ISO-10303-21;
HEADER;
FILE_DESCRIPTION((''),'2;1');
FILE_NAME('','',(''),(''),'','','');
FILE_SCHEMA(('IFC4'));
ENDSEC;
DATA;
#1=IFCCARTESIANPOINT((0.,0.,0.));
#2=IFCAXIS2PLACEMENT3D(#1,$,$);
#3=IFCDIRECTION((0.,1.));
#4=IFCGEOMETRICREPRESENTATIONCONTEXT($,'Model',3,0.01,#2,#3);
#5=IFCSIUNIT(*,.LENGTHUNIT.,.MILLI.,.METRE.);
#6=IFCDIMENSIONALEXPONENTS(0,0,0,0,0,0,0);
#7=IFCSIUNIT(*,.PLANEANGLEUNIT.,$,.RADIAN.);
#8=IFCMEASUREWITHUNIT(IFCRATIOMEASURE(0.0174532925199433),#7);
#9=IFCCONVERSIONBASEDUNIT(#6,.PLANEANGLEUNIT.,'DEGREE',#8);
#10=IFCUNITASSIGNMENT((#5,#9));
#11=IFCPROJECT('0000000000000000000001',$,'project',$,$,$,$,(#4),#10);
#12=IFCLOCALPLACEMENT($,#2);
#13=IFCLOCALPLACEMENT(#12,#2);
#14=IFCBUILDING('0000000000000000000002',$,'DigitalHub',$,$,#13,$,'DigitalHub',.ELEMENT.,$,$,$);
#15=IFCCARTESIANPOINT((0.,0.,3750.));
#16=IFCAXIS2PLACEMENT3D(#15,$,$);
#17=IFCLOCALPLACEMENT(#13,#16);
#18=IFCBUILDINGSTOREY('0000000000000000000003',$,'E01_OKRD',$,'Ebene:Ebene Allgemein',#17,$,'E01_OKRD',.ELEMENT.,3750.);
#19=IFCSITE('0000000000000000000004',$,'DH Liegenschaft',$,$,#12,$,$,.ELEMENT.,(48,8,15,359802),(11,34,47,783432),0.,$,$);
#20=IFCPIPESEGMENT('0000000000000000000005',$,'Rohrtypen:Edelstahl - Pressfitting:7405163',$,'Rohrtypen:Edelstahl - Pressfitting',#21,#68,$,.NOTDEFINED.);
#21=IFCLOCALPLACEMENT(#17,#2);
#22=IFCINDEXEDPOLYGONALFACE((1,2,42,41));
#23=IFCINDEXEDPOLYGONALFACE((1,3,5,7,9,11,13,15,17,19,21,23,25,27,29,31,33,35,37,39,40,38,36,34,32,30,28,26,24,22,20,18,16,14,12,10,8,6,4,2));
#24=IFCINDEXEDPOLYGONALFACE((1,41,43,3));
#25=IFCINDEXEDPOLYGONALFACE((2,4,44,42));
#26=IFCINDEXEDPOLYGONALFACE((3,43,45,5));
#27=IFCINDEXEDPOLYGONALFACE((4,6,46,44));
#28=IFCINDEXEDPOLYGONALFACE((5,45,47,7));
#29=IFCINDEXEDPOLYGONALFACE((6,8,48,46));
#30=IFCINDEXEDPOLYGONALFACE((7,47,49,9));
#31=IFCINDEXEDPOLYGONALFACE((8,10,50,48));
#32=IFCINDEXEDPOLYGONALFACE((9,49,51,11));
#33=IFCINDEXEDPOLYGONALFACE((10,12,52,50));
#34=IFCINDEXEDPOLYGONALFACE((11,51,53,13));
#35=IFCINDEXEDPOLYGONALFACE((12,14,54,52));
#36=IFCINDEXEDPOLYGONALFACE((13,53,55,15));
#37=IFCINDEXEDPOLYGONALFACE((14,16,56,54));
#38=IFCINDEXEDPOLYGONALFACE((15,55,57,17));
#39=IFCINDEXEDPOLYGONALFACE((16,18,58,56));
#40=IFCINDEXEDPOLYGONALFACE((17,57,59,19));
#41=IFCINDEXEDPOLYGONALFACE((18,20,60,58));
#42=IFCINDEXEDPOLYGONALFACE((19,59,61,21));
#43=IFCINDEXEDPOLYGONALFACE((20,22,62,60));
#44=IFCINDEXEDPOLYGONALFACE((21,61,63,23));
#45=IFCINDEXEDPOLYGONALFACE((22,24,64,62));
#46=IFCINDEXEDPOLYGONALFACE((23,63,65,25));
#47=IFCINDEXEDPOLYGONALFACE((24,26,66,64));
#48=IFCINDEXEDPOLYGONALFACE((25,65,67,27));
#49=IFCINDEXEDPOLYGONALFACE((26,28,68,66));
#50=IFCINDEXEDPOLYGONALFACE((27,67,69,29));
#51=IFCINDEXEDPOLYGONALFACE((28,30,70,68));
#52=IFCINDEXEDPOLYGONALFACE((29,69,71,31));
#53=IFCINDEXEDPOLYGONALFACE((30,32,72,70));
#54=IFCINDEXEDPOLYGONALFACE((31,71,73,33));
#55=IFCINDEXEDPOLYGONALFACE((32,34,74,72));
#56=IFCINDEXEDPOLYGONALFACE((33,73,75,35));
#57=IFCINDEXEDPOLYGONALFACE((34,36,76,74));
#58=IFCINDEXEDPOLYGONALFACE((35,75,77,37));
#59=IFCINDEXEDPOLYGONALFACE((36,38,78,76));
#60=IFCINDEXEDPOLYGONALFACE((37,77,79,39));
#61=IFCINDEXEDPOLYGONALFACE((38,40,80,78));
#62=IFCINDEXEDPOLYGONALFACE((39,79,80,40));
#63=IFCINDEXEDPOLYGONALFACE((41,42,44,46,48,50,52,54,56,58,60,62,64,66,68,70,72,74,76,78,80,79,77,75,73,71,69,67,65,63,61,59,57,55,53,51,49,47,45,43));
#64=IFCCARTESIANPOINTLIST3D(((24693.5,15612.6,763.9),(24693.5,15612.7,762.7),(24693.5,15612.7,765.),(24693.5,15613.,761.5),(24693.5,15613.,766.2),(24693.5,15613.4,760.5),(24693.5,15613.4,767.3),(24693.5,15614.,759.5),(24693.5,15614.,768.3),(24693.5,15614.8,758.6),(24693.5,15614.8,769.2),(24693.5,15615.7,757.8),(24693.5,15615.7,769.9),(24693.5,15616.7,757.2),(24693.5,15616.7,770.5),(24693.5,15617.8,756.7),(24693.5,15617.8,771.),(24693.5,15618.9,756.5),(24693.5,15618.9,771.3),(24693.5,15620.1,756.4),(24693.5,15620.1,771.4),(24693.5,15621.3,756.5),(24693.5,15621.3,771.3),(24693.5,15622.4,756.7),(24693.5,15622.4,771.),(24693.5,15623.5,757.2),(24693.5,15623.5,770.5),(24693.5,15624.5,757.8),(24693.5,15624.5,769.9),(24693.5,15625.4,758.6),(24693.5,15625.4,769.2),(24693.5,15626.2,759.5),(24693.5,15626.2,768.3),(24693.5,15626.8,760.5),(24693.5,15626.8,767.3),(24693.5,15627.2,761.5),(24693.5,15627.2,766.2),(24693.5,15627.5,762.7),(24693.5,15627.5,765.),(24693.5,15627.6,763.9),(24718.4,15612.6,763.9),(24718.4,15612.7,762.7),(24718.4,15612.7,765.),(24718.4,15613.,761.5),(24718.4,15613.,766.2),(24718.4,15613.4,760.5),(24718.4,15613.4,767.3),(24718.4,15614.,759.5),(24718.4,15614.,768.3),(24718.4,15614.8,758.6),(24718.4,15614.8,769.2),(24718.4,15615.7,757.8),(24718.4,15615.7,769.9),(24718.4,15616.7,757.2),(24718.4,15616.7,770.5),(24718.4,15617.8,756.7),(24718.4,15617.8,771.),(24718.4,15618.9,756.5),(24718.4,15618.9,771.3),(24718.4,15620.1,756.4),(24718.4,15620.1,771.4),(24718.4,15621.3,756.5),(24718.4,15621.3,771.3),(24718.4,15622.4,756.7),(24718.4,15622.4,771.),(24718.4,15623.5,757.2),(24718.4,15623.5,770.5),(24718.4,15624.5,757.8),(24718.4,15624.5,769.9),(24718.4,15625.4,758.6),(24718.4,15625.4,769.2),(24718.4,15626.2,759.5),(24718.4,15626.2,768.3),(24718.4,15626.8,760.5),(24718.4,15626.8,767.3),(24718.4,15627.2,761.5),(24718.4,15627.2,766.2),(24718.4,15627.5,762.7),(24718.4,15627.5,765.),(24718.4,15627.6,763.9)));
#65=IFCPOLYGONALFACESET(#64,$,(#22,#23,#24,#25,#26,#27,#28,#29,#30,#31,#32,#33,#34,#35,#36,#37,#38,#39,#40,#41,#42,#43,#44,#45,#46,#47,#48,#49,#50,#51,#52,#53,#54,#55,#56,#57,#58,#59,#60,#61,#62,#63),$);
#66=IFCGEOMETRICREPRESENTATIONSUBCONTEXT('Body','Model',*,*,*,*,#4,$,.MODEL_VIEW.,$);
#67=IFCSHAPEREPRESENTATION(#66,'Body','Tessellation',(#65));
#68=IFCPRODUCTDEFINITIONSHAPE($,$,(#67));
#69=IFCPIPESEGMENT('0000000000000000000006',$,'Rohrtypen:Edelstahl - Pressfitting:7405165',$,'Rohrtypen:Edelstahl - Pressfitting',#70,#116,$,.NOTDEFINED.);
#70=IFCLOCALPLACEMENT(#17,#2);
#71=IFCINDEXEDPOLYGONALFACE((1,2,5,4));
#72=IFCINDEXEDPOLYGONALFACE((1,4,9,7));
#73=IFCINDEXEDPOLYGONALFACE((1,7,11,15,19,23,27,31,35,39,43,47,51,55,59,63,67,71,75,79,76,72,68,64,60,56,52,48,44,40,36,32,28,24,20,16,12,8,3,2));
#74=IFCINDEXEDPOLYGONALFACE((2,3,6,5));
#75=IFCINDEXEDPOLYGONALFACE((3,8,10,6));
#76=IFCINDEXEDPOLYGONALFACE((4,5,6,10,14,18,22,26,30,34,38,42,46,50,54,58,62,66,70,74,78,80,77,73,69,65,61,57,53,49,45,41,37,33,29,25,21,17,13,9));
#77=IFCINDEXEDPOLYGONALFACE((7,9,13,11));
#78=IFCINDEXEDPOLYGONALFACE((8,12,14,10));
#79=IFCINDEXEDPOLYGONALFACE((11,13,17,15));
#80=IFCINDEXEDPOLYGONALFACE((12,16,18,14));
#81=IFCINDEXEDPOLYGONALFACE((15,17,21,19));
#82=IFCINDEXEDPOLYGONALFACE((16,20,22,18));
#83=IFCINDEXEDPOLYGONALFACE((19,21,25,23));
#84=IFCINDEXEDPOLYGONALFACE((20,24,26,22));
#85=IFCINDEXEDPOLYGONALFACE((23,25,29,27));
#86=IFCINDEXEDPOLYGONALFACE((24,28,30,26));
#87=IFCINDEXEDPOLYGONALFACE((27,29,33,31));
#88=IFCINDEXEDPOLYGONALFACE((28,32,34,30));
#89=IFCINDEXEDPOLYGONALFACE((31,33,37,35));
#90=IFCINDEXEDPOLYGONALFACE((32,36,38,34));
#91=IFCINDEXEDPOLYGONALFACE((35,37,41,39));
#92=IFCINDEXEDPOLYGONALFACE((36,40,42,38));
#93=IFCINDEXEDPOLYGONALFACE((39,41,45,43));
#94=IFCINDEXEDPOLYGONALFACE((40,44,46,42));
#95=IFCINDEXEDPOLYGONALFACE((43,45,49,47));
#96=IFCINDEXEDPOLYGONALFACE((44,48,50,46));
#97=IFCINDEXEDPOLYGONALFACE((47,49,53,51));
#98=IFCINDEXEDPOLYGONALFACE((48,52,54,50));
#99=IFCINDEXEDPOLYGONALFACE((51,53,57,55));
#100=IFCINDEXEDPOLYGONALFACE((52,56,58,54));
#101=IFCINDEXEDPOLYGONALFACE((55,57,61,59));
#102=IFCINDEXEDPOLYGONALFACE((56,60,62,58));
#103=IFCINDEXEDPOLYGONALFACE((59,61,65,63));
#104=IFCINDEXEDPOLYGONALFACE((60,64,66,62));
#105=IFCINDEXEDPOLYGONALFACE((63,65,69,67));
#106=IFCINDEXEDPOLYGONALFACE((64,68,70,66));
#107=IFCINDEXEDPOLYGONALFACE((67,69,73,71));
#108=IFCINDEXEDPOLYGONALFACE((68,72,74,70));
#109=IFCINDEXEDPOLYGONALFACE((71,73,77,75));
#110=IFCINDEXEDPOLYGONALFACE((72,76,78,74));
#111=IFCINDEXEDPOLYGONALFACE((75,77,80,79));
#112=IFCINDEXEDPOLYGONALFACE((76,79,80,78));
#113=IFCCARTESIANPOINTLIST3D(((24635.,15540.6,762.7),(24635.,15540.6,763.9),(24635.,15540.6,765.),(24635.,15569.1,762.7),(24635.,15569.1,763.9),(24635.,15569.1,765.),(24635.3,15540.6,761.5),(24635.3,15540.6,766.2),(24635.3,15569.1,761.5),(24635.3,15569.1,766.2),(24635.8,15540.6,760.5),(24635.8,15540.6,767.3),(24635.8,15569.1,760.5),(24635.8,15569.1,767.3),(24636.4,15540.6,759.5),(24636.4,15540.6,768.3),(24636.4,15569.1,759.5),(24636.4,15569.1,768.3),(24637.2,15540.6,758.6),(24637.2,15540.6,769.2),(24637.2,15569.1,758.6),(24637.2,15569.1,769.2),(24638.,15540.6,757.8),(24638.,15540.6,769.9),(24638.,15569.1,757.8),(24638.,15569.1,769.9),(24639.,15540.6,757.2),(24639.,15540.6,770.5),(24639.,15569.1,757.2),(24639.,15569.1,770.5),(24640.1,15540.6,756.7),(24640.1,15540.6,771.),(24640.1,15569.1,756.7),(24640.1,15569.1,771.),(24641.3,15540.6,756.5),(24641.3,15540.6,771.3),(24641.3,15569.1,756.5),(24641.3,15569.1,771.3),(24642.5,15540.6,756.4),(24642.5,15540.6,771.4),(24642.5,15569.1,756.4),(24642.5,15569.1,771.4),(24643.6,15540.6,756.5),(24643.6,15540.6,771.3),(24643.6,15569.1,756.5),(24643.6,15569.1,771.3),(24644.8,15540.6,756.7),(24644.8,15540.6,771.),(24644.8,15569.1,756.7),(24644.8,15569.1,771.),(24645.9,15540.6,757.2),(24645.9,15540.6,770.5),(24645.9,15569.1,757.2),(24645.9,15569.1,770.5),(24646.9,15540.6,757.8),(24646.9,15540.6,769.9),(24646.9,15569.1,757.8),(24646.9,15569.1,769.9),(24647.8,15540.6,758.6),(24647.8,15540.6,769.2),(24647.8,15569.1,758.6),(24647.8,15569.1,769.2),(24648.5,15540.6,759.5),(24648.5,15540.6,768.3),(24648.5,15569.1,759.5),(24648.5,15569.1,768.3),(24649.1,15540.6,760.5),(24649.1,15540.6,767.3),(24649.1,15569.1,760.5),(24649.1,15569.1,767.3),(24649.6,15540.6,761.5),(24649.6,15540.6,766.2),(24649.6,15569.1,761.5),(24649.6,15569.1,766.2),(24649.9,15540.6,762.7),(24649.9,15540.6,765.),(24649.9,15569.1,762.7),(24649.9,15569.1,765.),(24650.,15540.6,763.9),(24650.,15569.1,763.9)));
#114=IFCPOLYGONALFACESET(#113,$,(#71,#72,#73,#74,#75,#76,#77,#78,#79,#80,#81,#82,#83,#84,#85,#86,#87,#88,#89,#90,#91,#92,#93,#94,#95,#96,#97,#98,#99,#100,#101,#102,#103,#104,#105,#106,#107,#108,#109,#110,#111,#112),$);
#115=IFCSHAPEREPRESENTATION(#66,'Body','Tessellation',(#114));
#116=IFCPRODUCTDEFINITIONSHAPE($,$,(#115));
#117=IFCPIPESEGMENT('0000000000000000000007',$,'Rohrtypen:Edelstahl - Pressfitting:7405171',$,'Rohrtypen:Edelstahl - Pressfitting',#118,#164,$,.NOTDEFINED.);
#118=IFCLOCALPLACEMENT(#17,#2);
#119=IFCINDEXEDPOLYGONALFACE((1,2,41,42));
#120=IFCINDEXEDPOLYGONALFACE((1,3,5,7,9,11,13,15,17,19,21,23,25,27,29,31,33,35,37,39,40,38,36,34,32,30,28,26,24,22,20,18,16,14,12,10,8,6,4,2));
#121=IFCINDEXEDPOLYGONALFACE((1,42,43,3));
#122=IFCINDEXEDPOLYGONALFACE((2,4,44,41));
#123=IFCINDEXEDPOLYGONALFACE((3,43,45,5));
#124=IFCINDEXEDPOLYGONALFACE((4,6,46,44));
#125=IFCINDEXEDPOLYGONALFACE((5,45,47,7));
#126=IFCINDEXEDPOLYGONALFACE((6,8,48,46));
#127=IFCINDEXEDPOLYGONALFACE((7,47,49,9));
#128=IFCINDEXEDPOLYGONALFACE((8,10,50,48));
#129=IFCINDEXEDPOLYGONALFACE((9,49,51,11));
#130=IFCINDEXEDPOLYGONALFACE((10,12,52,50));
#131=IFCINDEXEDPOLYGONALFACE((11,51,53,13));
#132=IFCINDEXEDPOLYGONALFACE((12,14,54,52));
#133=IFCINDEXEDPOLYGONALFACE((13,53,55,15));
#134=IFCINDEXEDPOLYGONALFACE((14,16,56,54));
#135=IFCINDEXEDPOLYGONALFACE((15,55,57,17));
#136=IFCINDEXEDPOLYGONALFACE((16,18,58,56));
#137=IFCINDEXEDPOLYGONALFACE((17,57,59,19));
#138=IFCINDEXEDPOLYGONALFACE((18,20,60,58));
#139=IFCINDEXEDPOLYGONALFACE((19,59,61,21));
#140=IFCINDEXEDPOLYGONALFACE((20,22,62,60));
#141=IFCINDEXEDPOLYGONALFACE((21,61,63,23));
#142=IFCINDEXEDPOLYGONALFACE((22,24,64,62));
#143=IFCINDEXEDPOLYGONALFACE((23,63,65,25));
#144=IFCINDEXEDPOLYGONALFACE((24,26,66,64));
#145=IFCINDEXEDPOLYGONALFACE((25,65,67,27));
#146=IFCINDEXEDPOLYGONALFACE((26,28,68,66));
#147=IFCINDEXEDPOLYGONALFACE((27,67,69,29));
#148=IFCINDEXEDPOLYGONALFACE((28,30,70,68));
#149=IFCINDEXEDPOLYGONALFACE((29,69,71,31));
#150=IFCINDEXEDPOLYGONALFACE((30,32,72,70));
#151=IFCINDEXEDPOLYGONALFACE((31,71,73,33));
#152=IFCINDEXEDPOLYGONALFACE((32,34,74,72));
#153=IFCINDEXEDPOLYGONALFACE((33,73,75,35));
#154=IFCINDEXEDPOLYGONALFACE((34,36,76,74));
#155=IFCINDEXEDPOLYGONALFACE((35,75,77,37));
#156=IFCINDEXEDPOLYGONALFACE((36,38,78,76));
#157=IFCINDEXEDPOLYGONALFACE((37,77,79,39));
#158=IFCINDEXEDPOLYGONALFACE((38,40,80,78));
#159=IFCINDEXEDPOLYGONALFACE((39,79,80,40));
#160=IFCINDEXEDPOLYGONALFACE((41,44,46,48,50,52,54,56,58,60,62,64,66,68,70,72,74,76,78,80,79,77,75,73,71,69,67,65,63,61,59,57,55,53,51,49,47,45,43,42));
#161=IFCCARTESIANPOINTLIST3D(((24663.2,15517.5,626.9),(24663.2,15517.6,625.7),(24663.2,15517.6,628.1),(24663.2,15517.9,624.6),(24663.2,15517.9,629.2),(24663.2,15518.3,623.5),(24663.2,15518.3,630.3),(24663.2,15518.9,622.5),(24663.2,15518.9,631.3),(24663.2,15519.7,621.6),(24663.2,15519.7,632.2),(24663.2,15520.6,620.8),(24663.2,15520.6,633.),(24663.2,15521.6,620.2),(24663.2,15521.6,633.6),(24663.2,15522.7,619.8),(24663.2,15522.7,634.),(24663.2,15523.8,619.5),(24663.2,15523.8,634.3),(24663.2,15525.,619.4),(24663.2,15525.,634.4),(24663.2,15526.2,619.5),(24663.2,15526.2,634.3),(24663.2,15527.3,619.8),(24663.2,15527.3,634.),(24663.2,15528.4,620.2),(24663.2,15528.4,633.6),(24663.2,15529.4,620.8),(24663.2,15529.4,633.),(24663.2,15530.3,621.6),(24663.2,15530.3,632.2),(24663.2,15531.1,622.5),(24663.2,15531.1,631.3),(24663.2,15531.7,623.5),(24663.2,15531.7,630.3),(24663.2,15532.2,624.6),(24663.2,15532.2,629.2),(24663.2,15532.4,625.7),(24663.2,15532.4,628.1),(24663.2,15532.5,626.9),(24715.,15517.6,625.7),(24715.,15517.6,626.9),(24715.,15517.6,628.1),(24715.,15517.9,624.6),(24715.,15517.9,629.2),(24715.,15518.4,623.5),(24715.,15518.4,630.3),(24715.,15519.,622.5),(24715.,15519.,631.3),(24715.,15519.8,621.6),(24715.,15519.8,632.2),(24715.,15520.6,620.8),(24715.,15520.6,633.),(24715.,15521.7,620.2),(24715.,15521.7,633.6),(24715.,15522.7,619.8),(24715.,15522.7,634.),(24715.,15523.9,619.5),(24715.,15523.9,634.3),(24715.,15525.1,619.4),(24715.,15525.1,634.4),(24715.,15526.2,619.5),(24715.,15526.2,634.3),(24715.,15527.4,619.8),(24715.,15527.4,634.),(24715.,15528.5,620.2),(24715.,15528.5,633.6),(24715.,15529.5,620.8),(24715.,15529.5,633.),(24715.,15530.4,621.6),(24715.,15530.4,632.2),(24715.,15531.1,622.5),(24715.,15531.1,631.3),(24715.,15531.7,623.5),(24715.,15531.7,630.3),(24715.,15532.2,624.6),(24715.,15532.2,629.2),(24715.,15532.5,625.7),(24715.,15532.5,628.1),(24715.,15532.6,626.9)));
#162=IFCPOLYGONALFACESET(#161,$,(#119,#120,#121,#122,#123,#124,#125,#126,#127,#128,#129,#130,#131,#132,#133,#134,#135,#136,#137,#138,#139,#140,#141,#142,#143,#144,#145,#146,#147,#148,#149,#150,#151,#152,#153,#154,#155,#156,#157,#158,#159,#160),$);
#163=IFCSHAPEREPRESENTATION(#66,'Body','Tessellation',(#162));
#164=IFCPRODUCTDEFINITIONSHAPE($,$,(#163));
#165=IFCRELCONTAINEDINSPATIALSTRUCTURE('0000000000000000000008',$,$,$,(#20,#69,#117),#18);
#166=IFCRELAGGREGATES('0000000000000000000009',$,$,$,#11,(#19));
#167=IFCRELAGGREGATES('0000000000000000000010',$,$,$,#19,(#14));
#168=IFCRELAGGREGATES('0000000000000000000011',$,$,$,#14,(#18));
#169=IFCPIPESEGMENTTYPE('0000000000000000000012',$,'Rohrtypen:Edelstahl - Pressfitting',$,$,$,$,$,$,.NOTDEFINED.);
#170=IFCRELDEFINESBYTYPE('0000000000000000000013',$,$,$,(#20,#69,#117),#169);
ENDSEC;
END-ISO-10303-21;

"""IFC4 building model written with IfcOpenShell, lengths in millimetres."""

from ifc_helpers import new_model, entity, si_unit, converted_unit, direction, frame, origin, place, context, subcontext, project, spatial, indexed_curve, outline, extrude, type_object, element, save


model = new_model("IFC4")

# Units and contexts
model_context = context("Model", 3, precision=0.01, world=origin(), true_north=direction((0.0, 1.0)))
body_context = subcontext(model_context, "Body", "Model", "MODEL_VIEW")
ifc_project = project(units=[si_unit("LENGTHUNIT", "METRE", prefix="MILLI"), converted_unit("PLANEANGLEUNIT", "DEGREE", entity("IfcRatioMeasure", 0.0174532925199433), si_unit("PLANEANGLEUNIT", "RADIAN"), dimensions=[0, 0, 0, 0, 0, 0, 0])], contexts=[model_context])

# Site, building, storey
site_placement = place(None, origin())
site = spatial("IfcSite", under=ifc_project, at=site_placement, Name="DH Liegenschaft", CompositionType="ELEMENT", RefLatitude=(48, 8, 15, 359802), RefLongitude=(11, 34, 47, 783432), RefElevation=0.0)
building_placement = place(site_placement, origin())
building = spatial("IfcBuilding", under=site, at=building_placement, Name="DigitalHub", LongName="DigitalHub", CompositionType="ELEMENT")
storey_placement = place(building_placement, frame((0.0, 0.0, 3750.0)))
storey = spatial("IfcBuildingStorey", under=building, at=storey_placement, Name="E01_OKRD", ObjectType="Ebene:Ebene Allgemein", LongName="E01_OKRD", CompositionType="ELEMENT", Elevation=3750.0)

# Pipe segments
pipe_segment_type_1 = type_object("IfcPipeSegmentType", Name="Rohrtypen:Edelstahl - Pressfitting", PredefinedType="NOTDEFINED")
pipe_segment_1_placement = place(storey_placement, frame((24693.5, 15611.0, 754.8)))
element("IfcPipeSegment", 1, at=pipe_segment_1_placement, inside=storey, type_object=pipe_segment_type_1, Name="Rohrtypen:Edelstahl - Pressfitting:7405163", ObjectType="Rohrtypen:Edelstahl - Pressfitting", PredefinedType="NOTDEFINED", context=body_context, shape_type="SweptSolid", body=[
    extrude(outline(indexed_curve([(7.5, 0.0), (7.4, 1.2), (7.1, 2.3), (6.7, 3.4), (6.1, 4.4), (5.3, 5.3), (4.4, 6.1), (3.4, 6.7), (2.3, 7.1), (1.2, 7.4), (0.0, 7.5), (-1.2, 7.4), (-2.3, 7.1), (-3.4, 6.7), (-4.4, 6.1), (-5.3, 5.3), (-6.1, 4.4), (-6.7, 3.4), (-7.1, 2.3), (-7.4, 1.2), (-7.5, 0.0), (-7.4, -1.2), (-7.1, -2.3), (-6.7, -3.4), (-6.1, -4.4), (-5.3, -5.3), (-4.4, -6.1), (-3.4, -6.7), (-2.3, -7.1), (-1.2, -7.4), (0.0, -7.5), (1.2, -7.4), (2.3, -7.1), (3.4, -6.7), (4.4, -6.1), (5.3, -5.3), (6.1, -4.4), (6.7, -3.4), (7.1, -2.3), (7.4, -1.2), (7.5, 0.0)], self_intersect=False)), frame((0.0, 9.1, 9.1), z_axis=(1.0, 0.0, 0.0), x_axis=(0.0, 1.0, 0.0)), (0.0, 0.0, 1.0), 24.9),
])
pipe_segment_2_placement = place(storey_placement, frame((24633.4, 15540.6, 754.8)))
element("IfcPipeSegment", 2, at=pipe_segment_2_placement, inside=storey, type_object=pipe_segment_type_1, Name="Rohrtypen:Edelstahl - Pressfitting:7405165", ObjectType="Rohrtypen:Edelstahl - Pressfitting", PredefinedType="NOTDEFINED", context=body_context, shape_type="SweptSolid", body=[
    extrude(outline(indexed_curve([(7.5, 0.0), (7.4, 1.2), (7.1, 2.3), (6.7, 3.4), (6.1, 4.4), (5.3, 5.3), (4.4, 6.1), (3.4, 6.7), (2.3, 7.1), (1.2, 7.4), (0.0, 7.5), (-1.2, 7.4), (-2.3, 7.1), (-3.4, 6.7), (-4.4, 6.1), (-5.3, 5.3), (-6.1, 4.4), (-6.7, 3.4), (-7.1, 2.3), (-7.4, 1.2), (-7.5, 0.0), (-7.4, -1.2), (-7.1, -2.3), (-6.7, -3.4), (-6.1, -4.4), (-5.3, -5.3), (-4.4, -6.1), (-3.4, -6.7), (-2.3, -7.1), (-1.2, -7.4), (0.0, -7.5), (1.2, -7.4), (2.3, -7.1), (3.4, -6.7), (4.4, -6.1), (5.3, -5.3), (6.1, -4.4), (6.7, -3.4), (7.1, -2.3), (7.4, -1.2), (7.5, 0.0)], self_intersect=False)), frame((9.1, 0.0, 9.1), z_axis=(0.0, 1.0, 0.0), x_axis=(-1.0, 0.0, 0.0)), (0.0, 0.0, 1.0), 28.5),
])
pipe_segment_3_placement = place(storey_placement, frame((24663.2, 15515.9, 617.8)))
element("IfcPipeSegment", 3, at=pipe_segment_3_placement, inside=storey, type_object=pipe_segment_type_1, Name="Rohrtypen:Edelstahl - Pressfitting:7405171", ObjectType="Rohrtypen:Edelstahl - Pressfitting", PredefinedType="NOTDEFINED", context=body_context, shape_type="SweptSolid", body=[
    extrude(outline(indexed_curve([(7.5, 0.0), (7.4, 1.2), (7.1, 2.3), (6.7, 3.4), (6.1, 4.4), (5.3, 5.3), (4.4, 6.1), (3.4, 6.7), (2.3, 7.1), (1.2, 7.4), (0.0, 7.5), (-1.2, 7.4), (-2.3, 7.1), (-3.4, 6.7), (-4.4, 6.1), (-5.3, 5.3), (-6.1, 4.4), (-6.7, 3.4), (-7.1, 2.3), (-7.4, 1.2), (-7.5, 0.0), (-7.4, -1.2), (-7.1, -2.3), (-6.7, -3.4), (-6.1, -4.4), (-5.3, -5.3), (-4.4, -6.1), (-3.4, -6.7), (-2.3, -7.1), (-1.2, -7.4), (0.0, -7.5), (1.2, -7.4), (2.3, -7.1), (3.4, -6.7), (4.4, -6.1), (5.3, -5.3), (6.1, -4.4), (6.7, -3.4), (7.1, -2.3), (7.4, -1.2), (7.5, 0.0)], self_intersect=False)), frame((0.0, 9.1, 9.1), z_axis=(1.0, 0.000766, 0.0), x_axis=(-0.000766, 1.0, 0.0)), (0.0, 0.0, 1.0), 51.8),
])

save(model, "model.ifc")
